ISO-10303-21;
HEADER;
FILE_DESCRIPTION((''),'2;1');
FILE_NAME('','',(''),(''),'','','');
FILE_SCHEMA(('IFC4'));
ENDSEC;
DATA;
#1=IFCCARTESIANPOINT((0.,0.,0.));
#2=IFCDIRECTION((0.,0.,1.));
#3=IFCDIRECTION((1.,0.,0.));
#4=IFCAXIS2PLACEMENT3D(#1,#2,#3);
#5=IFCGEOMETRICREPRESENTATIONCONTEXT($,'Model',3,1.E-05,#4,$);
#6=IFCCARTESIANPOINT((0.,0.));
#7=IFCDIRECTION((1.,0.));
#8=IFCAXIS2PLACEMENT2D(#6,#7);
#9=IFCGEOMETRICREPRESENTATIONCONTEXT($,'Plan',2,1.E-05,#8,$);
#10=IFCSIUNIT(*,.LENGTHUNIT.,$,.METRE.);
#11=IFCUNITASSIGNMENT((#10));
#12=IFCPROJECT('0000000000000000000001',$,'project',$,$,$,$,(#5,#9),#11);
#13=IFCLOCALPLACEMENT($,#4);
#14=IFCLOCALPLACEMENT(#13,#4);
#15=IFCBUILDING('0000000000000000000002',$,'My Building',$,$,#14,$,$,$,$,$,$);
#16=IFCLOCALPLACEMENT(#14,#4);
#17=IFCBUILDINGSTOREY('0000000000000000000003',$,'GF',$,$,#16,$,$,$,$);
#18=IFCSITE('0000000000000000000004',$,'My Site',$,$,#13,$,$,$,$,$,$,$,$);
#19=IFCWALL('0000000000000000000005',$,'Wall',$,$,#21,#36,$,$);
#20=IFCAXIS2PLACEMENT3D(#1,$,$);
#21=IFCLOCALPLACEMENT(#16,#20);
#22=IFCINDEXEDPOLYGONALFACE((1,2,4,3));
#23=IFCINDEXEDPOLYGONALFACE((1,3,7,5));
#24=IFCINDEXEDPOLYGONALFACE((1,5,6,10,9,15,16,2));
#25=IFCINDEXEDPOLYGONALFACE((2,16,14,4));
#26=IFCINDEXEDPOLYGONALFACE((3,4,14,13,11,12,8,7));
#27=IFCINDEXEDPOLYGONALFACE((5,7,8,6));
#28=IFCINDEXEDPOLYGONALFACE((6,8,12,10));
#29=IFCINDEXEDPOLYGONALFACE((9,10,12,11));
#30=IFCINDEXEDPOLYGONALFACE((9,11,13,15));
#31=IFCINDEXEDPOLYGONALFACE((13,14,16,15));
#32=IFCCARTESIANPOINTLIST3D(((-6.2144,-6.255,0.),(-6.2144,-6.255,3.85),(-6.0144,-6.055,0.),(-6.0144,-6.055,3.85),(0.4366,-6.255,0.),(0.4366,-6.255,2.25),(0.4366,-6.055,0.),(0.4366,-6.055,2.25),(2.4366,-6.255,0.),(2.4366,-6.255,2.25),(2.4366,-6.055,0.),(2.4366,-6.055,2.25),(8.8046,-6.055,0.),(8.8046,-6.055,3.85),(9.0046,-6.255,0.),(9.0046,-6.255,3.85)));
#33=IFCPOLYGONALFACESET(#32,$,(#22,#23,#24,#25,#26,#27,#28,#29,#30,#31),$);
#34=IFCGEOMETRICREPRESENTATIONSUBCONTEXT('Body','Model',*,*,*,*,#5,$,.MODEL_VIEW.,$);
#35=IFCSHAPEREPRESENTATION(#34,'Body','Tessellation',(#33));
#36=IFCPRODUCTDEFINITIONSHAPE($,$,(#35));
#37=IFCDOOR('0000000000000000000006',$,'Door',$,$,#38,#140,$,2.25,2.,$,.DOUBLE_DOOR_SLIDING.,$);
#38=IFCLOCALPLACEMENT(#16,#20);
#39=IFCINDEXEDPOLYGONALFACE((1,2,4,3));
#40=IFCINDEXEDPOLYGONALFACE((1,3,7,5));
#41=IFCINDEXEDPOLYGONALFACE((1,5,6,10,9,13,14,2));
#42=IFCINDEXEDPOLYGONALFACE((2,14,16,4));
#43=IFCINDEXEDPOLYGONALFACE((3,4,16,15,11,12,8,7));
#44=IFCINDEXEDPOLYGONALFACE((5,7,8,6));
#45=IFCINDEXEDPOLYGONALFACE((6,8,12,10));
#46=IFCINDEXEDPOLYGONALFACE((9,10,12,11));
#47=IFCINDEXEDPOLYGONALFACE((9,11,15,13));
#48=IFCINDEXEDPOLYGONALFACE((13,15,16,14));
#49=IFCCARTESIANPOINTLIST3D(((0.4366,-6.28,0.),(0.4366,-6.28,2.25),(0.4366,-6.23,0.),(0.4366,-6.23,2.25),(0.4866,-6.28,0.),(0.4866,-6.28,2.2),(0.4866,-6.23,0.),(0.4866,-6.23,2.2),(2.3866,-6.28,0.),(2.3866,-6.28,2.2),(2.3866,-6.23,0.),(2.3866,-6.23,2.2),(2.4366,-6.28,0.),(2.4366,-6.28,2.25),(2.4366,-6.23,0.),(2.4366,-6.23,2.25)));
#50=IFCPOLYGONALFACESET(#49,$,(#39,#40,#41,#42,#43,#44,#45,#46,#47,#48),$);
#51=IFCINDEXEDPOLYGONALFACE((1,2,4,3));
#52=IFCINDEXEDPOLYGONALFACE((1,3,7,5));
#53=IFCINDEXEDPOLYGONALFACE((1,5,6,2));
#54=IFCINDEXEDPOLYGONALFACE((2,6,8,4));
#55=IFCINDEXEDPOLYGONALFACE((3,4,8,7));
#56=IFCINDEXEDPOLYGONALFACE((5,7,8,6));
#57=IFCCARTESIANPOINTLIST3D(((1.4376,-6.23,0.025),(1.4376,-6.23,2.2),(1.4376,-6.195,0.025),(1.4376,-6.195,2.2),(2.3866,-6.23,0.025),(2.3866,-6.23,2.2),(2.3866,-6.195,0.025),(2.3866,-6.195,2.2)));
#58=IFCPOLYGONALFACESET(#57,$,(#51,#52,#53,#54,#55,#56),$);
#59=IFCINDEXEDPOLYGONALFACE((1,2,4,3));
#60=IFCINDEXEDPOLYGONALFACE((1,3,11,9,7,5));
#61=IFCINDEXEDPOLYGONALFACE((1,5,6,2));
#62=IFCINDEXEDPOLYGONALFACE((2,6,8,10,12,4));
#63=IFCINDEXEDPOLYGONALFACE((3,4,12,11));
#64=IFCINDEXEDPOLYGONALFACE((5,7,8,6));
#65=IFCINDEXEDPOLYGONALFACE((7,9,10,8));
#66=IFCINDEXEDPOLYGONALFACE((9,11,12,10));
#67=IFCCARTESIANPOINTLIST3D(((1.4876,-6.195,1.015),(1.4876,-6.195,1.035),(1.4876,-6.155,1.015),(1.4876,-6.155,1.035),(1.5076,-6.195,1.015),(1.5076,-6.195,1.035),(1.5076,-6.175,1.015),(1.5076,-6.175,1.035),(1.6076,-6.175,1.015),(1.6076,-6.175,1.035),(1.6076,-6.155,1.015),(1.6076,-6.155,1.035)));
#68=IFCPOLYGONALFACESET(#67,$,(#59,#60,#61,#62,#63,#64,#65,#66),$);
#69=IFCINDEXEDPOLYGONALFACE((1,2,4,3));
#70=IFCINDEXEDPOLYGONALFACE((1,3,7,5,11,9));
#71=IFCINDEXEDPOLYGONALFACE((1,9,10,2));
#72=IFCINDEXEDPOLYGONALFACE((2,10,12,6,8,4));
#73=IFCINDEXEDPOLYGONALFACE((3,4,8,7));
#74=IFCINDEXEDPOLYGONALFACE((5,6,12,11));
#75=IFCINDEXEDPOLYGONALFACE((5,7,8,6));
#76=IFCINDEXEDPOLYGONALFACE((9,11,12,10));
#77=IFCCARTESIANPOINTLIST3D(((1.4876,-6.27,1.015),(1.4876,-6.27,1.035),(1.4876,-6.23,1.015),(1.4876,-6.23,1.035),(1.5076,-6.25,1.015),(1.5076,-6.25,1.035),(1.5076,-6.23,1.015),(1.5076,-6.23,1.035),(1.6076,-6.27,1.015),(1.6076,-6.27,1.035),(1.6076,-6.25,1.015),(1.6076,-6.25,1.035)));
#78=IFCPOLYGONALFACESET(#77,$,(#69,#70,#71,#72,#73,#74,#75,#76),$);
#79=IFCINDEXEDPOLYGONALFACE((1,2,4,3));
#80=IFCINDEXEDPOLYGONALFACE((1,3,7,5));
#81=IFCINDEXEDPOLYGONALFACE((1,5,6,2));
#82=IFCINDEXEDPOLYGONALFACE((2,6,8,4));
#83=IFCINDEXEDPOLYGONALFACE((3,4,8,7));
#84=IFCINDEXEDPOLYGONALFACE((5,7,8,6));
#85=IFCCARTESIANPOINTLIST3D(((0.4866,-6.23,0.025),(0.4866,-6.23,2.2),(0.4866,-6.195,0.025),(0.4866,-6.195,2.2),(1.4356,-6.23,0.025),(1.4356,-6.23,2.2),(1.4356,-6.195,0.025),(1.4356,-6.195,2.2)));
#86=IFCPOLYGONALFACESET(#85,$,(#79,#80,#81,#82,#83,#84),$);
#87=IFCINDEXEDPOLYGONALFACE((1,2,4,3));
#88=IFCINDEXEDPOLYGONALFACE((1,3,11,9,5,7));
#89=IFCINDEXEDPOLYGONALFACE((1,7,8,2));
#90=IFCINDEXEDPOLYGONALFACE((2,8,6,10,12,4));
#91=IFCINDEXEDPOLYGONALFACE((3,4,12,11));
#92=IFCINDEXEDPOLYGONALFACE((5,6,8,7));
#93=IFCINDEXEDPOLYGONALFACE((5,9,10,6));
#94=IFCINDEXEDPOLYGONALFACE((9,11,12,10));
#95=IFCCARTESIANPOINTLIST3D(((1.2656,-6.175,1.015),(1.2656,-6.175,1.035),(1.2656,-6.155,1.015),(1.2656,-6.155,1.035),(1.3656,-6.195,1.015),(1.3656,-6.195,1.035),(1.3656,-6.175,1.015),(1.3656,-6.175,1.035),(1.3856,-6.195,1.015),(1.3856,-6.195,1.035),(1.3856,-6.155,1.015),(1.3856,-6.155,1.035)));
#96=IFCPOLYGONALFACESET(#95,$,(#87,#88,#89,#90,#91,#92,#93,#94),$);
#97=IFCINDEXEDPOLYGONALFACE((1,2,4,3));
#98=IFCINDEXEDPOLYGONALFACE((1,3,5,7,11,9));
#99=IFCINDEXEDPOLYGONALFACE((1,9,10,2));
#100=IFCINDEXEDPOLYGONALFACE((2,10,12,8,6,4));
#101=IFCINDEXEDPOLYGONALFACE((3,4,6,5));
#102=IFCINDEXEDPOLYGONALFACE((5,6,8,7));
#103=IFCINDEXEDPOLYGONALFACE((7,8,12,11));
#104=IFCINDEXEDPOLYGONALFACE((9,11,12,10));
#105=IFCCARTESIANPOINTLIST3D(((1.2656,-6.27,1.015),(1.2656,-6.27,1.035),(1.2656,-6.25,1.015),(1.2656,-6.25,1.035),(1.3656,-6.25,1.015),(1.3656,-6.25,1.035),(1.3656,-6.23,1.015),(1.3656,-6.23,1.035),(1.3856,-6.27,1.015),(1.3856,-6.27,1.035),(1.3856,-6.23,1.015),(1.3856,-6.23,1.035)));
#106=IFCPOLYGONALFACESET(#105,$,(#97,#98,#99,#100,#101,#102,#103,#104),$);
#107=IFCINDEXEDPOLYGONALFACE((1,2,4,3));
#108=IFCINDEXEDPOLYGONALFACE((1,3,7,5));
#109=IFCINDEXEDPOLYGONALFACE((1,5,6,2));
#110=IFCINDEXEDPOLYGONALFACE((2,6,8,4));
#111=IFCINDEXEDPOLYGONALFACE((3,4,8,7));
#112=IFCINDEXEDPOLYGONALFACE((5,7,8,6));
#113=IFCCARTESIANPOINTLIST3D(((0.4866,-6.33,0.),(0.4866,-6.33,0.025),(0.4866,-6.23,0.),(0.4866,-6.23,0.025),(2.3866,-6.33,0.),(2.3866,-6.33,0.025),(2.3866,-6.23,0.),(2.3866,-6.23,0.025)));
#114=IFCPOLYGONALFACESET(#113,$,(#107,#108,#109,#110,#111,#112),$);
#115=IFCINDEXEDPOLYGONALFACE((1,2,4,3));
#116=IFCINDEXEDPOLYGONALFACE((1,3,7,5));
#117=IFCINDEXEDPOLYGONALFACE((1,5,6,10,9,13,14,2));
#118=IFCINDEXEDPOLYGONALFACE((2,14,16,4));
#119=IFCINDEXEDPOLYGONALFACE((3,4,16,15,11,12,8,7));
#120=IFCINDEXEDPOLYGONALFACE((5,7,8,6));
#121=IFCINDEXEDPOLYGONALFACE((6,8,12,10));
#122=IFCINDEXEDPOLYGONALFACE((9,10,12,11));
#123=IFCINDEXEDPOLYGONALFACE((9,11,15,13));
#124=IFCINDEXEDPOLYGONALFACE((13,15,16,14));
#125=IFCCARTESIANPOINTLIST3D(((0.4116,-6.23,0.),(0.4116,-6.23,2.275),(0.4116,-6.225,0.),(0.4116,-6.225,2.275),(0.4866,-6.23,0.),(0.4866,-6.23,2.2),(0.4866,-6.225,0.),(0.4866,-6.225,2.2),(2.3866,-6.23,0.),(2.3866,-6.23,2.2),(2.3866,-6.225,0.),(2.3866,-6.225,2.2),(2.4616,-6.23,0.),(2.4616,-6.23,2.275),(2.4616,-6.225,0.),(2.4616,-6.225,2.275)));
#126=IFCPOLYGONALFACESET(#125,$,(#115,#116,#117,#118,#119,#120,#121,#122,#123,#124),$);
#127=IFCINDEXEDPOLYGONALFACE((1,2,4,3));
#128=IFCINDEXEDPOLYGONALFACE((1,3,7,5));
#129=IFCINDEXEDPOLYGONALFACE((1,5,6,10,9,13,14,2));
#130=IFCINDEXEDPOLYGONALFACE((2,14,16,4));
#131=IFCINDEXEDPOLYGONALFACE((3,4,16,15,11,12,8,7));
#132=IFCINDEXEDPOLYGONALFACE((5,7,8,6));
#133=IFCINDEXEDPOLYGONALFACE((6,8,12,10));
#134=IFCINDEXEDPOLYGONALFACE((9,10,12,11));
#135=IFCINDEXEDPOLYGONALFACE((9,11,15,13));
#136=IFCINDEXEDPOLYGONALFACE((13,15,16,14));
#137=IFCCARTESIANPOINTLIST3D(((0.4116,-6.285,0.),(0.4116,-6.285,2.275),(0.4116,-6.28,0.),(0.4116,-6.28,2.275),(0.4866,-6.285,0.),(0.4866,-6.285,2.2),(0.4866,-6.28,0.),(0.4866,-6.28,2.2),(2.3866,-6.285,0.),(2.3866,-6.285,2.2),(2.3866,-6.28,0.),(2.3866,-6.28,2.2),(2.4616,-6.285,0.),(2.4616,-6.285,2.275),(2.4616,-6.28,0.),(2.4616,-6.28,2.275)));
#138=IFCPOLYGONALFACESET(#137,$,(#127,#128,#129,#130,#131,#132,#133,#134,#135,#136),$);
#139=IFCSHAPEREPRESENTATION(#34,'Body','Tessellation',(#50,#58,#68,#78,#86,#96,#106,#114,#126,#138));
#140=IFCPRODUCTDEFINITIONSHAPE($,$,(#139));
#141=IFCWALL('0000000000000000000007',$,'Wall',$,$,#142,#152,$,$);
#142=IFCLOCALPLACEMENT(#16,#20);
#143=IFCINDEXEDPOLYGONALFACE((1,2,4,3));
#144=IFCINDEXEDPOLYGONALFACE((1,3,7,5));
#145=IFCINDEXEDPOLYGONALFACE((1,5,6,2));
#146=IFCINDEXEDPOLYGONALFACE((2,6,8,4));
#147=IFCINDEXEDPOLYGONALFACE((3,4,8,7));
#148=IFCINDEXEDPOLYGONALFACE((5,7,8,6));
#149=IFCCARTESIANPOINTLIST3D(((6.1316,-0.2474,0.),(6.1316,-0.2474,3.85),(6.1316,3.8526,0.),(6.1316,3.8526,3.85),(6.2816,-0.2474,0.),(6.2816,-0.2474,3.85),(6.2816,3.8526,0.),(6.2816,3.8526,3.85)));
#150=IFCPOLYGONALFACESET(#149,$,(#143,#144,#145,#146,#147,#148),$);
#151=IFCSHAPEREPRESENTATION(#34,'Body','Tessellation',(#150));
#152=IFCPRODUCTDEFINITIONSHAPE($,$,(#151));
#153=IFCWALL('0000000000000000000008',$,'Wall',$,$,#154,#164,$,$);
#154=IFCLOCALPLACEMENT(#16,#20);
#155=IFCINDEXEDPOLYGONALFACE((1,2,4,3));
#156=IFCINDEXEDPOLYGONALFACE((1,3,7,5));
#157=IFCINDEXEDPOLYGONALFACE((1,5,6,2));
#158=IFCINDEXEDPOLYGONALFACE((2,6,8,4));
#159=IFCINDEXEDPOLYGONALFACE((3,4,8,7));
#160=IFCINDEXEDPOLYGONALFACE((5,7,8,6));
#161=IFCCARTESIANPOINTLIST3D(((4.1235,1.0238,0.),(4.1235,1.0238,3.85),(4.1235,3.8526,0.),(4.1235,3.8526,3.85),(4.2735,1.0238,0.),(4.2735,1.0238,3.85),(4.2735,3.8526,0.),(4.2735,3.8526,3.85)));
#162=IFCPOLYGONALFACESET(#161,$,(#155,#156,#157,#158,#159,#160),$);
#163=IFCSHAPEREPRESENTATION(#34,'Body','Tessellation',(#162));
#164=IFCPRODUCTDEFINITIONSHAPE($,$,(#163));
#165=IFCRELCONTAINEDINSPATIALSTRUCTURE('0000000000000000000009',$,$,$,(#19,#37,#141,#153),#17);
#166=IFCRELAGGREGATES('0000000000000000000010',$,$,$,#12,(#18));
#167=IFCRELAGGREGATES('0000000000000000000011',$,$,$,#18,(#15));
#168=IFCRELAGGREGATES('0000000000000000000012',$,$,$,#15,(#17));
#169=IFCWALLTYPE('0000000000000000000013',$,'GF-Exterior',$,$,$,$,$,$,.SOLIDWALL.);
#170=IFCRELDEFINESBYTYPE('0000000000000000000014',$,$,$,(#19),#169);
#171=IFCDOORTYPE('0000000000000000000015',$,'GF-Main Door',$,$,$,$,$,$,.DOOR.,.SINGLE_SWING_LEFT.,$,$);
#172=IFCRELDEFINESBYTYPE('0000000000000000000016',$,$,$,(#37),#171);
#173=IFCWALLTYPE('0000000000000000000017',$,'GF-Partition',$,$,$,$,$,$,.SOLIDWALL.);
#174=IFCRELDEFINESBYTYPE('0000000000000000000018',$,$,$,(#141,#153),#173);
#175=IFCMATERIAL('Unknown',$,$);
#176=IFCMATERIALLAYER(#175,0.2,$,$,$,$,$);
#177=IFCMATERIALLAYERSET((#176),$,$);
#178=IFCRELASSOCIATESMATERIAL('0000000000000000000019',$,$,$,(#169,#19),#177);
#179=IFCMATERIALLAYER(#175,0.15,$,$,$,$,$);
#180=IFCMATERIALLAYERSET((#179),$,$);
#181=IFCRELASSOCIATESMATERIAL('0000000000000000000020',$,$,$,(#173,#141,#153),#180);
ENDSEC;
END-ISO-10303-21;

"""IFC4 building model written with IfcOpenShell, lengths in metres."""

from ifc_helpers import new_model, entity, si_unit, frame, origin_with_axes, origin_2d_with_axis, place, context, subcontext, project, spatial, line, indexed_curve, outline, extrude, shape, source, transform, mapped, material, layer, layer_set, layer_usage, type_object, type_shapes, element, fill, save


model = new_model("IFC4")

# Units and contexts
model_context = context("Model", 3, precision=1e-05, world=origin_with_axes())
plan_context = context("Plan", 2, precision=1e-05, world=origin_2d_with_axis())
body_context_1 = subcontext(model_context, "Body", "Model", "MODEL_VIEW")
body_context_2 = subcontext(plan_context, "Body", "Plan", "PLAN_VIEW")
ifc_project = project(units=[si_unit("LENGTHUNIT", "METRE")], contexts=[model_context, plan_context])

# Site, building, storey
site_placement = place(None, origin_with_axes())
site = spatial("IfcSite", under=ifc_project, at=site_placement, Name="My Site")
building_placement = place(site_placement, origin_with_axes())
building = spatial("IfcBuilding", under=site, at=building_placement, Name="My Building")
storey_placement = place(building_placement, origin_with_axes())
storey = spatial("IfcBuildingStorey", under=building, at=storey_placement, Name="GF")

# Shared definitions
ifc_material = material(Name="Unknown")

# Shared definitions
ifc_layer_1 = layer(ifc_material, 0.2)
ifc_layer_set_1 = layer_set([ifc_layer_1])
wall_type_1 = type_object("IfcWallType", Name="GF-Exterior", PredefinedType="SOLIDWALL", material=ifc_layer_set_1)

# Wall, opening, door
ifc_layer_usage_1 = layer_usage(ifc_layer_set_1, "AXIS2", "POSITIVE", 0.0)
wall_1_placement = place(storey_placement, frame((8.8046, -6.055, 0.0), z_axis=(0.0, 0.0, 1.0), x_axis=(-1.0, 0.0, 0.0)))
wall_1 = element("IfcWall", 1, at=wall_1_placement, inside=storey, type_object=wall_type_1, material=ifc_layer_usage_1, Name="Wall", context=body_context_1, shape_type="SweptSolid", body=[
    extrude(outline(indexed_curve([(0.0, 0.0), (-0.2, 0.2), (15.019, 0.2), (14.819, 0.0)], segments=[line(1, 2, 3, 4, 1)])), origin_with_axes(), (0.0, 0.0, 1.0), 3.85),
])
shared_shape_1 = source(origin_with_axes(), body_context_1, "Body", "SweptSolid", [
    extrude(outline(indexed_curve([(0.0, 0.0), (2.0, 0.0), (2.0, 2.25), (0.0, 2.25)], segments=[line(1, 2, 3, 4, 1)])), frame((0.0, -0.6, 0.0), z_axis=(0.0, -1.0, 0.0), x_axis=(1.0, 0.0, 0.0)), (0.0, 0.0, -1.0), 1.2),
])
opening_1_placement = place(wall_1_placement, frame((6.368, 0.175, 0.0), z_axis=(0.0, 0.0, 1.0), x_axis=(1.0, 0.0, 0.0)))
opening_1 = element("IfcOpeningElement", 2, at=opening_1_placement, cuts=wall_1, PredefinedType="OPENING", context=body_context_1, shape_type="MappedRepresentation", body=[
    mapped(shared_shape_1, transform((0.0, 0.0, 0.0), x_axis=(1.0, 0.0, 0.0), y_axis=(0.0, 1.0, 0.0), z_axis=(0.0, 0.0, 1.0), scale=1.0)),
])
door_type_1 = type_object("IfcDoorType", Name="GF-Main Door", OperationType="SINGLE_SWING_LEFT", PredefinedType="DOOR")
shared_shape_2 = source(origin_with_axes(), body_context_1, "Body", "SweptSolid", [
    extrude(outline(indexed_curve([(0.0, 0.0), (0.0, 2.25), (2.0, 2.25), (2.0, 0.0), (1.95, 0.0), (1.95, 2.2), (0.05, 2.2), (0.05, 0.0)], segments=[line(1, 2, 3, 4, 5, 6, 7, 8, 1)])), frame((0.0, 0.0, 0.0), z_axis=(0.0, -1.0, 0.0), x_axis=(1.0, 0.0, 0.0)), (0.0, 0.0, -1.0), 0.05),
    extrude(outline(indexed_curve([(0.0, 0.0), (0.949, 0.0), (0.949, 0.035), (0.0, 0.035)], segments=[line(1, 2, 3, 4, 1)])), frame((0.05, -0.035, 0.025), z_axis=(0.0, 0.0, 1.0), x_axis=(1.0, 0.0, 0.0)), (0.0, 0.0, 1.0), 2.175),
    extrude(outline(indexed_curve([(0.0, 0.0), (0.0, -0.04), (-0.12, -0.04), (-0.12, -0.02), (-0.02, -0.02), (-0.02, 0.0)], segments=[line(1, 2, 3, 4, 5, 6, 1)])), frame((0.949, -0.035, 1.015), z_axis=(0.0, 0.0, 1.0), x_axis=(1.0, 0.0, 0.0)), (0.0, 0.0, 1.0), 0.02),
    extrude(outline(indexed_curve([(0.0, 0.0), (0.0, 0.04), (-0.12, 0.04), (-0.12, 0.02), (-0.02, 0.02), (-0.02, 0.0)], segments=[line(1, 2, 3, 4, 5, 6, 1)])), frame((0.949, 0.0, 1.015), z_axis=(0.0, 0.0, 1.0), x_axis=(1.0, 0.0, 0.0)), (0.0, 0.0, 1.0), 0.02),
    extrude(outline(indexed_curve([(0.0, 0.0), (-0.949, 0.0), (-0.949, 0.035), (0.0, 0.035)], segments=[line(1, 2, 3, 4, 1)])), frame((1.95, -0.035, 0.025), z_axis=(0.0, 0.0, 1.0), x_axis=(1.0, 0.0, 0.0)), (0.0, 0.0, 1.0), 2.175),
    extrude(outline(indexed_curve([(0.0, 0.0), (0.0, -0.04), (0.12, -0.04), (0.12, -0.02), (0.02, -0.02), (0.02, 0.0)], segments=[line(1, 2, 3, 4, 5, 6, 1)])), frame((1.051, -0.035, 1.015), z_axis=(0.0, 0.0, 1.0), x_axis=(1.0, 0.0, 0.0)), (0.0, 0.0, 1.0), 0.02),
    extrude(outline(indexed_curve([(0.0, 0.0), (0.0, 0.04), (0.12, 0.04), (0.12, 0.02), (0.02, 0.02), (0.02, 0.0)], segments=[line(1, 2, 3, 4, 5, 6, 1)])), frame((1.051, 0.0, 1.015), z_axis=(0.0, 0.0, 1.0), x_axis=(1.0, 0.0, 0.0)), (0.0, 0.0, 1.0), 0.02),
    extrude(outline(indexed_curve([(0.0, 0.0), (1.9, 0.0), (1.9, 0.1), (0.0, 0.1)], segments=[line(1, 2, 3, 4, 1)])), frame((0.05, 0.0, 0.0), z_axis=(0.0, 0.0, 1.0), x_axis=(1.0, 0.0, 0.0)), (0.0, 0.0, 1.0), 0.025),
    extrude(outline(indexed_curve([(0.0, 0.0), (0.0, 2.275), (2.05, 2.275), (2.05, 0.0), (1.975, 0.0), (1.975, 2.2), (0.075, 2.2), (0.075, 0.0)], segments=[line(1, 2, 3, 4, 5, 6, 7, 8, 1)])), frame((-0.025, -0.005, 0.0), z_axis=(0.0, -1.0, 0.0), x_axis=(1.0, 0.0, 0.0)), (0.0, 0.0, -1.0), 0.005),
    extrude(outline(indexed_curve([(0.0, 0.0), (0.0, 2.275), (2.05, 2.275), (2.05, 0.0), (1.975, 0.0), (1.975, 2.2), (0.075, 2.2), (0.075, 0.0)], segments=[line(1, 2, 3, 4, 5, 6, 7, 8, 1)])), frame((-0.025, 0.05, 0.0), z_axis=(0.0, -1.0, 0.0), x_axis=(1.0, 0.0, 0.0)), (0.0, 0.0, -1.0), 0.005),
])
shared_shape_3 = source(origin_with_axes(), body_context_2, "Body", "Curve2D", [
    entity("IfcIndexedPolyCurve", entity("IfcCartesianPointList2D", [[0.0, 0.0], [0.05, 0.0], [0.05, 0.05], [0.0, 0.05]]), [entity("IfcLineIndex", [1, 2, 3, 4, 1])]),
    entity("IfcIndexedPolyCurve", entity("IfcCartesianPointList2D", [[2.0, 0.0], [1.95, 0.0], [1.95, 0.05], [2.0, 0.05]]), [entity("IfcLineIndex", [1, 2, 3, 4, 1])]),
    entity("IfcIndexedPolyCurve", entity("IfcCartesianPointList2D", [[-0.425, -0.035], [0.525, -0.035], [0.525, 0.0], [-0.425, 0.0]]), [entity("IfcLineIndex", [1, 2, 3, 4, 1])]),
    entity("IfcIndexedPolyCurve", entity("IfcCartesianPointList2D", [[2.425, -0.035], [1.475, -0.035], [1.475, 0.0], [2.425, 0.0]]), [entity("IfcLineIndex", [1, 2, 3, 4, 1])]),
])
type_shapes(door_type_1, [shared_shape_2, shared_shape_3])
door_1_placement = place(opening_1_placement, frame((0.0, 0.0, 0.0), z_axis=(0.0, 0.0, 1.0), x_axis=(1.0, 0.0, 0.0)))
door_1 = element("IfcDoor", 3, at=door_1_placement, inside=storey, type_object=door_type_1, Name="Door", OperationType="DOUBLE_DOOR_SLIDING", OverallHeight=2.25, OverallWidth=2.0, shapes=[
    shape(body_context_1, "Body", "MappedRepresentation", [mapped(shared_shape_2, transform((0.0, 0.0, 0.0), x_axis=(1.0, 0.0, 0.0), y_axis=(0.0, 1.0, 0.0), z_axis=(0.0, 0.0, 1.0), scale=1.0))]),
    shape(body_context_2, "Body", "MappedRepresentation", [mapped(shared_shape_3, transform((0.0, 0.0, 0.0), x_axis=(1.0, 0.0, 0.0), y_axis=(0.0, 1.0, 0.0), z_axis=(0.0, 0.0, 1.0), scale=1.0))]),
])
fill(opening_1, door_1)

# Wall
ifc_layer_2 = layer(ifc_material, 0.15)
ifc_layer_set_2 = layer_set([ifc_layer_2])
ifc_layer_usage_2 = layer_usage(ifc_layer_set_2, "AXIS2", "POSITIVE", 0.0)
wall_type_2 = type_object("IfcWallType", Name="GF-Partition", PredefinedType="SOLIDWALL", material=ifc_layer_set_2)
wall_2_placement = place(storey_placement, frame((6.1316, 3.8526, 0.0), z_axis=(0.0, 0.0, 1.0), x_axis=(0.0, -1.0, 0.0)))
element("IfcWall", 4, at=wall_2_placement, inside=storey, type_object=wall_type_2, material=ifc_layer_usage_2, Name="Wall", context=body_context_1, shape_type="SweptSolid", body=[
    extrude(outline(indexed_curve([(0.0, 0.0), (0.0, 0.15), (4.1, 0.15), (4.1, 0.0)], segments=[line(1, 2, 3, 4, 1)])), origin_with_axes(), (0.0, 0.0, 1.0), 3.85),
])

# Wall
ifc_layer_usage_3 = layer_usage(ifc_layer_set_2, "AXIS2", "POSITIVE", 0.0)
wall_3_placement = place(storey_placement, frame((4.2735, 1.0238, 0.0), z_axis=(0.0, 0.0, 1.0), x_axis=(0.0, 1.0, 0.0)))
element("IfcWall", 5, at=wall_3_placement, inside=storey, type_object=wall_type_2, material=ifc_layer_usage_3, Name="Wall", context=body_context_1, shape_type="SweptSolid", body=[
    extrude(outline(indexed_curve([(0.0, 0.0), (0.0, 0.15), (2.8288, 0.15), (2.8288, 0.0)], segments=[line(1, 2, 3, 4, 1)])), origin_with_axes(), (0.0, 0.0, 1.0), 3.85),
])

save(model, "model.ifc")
